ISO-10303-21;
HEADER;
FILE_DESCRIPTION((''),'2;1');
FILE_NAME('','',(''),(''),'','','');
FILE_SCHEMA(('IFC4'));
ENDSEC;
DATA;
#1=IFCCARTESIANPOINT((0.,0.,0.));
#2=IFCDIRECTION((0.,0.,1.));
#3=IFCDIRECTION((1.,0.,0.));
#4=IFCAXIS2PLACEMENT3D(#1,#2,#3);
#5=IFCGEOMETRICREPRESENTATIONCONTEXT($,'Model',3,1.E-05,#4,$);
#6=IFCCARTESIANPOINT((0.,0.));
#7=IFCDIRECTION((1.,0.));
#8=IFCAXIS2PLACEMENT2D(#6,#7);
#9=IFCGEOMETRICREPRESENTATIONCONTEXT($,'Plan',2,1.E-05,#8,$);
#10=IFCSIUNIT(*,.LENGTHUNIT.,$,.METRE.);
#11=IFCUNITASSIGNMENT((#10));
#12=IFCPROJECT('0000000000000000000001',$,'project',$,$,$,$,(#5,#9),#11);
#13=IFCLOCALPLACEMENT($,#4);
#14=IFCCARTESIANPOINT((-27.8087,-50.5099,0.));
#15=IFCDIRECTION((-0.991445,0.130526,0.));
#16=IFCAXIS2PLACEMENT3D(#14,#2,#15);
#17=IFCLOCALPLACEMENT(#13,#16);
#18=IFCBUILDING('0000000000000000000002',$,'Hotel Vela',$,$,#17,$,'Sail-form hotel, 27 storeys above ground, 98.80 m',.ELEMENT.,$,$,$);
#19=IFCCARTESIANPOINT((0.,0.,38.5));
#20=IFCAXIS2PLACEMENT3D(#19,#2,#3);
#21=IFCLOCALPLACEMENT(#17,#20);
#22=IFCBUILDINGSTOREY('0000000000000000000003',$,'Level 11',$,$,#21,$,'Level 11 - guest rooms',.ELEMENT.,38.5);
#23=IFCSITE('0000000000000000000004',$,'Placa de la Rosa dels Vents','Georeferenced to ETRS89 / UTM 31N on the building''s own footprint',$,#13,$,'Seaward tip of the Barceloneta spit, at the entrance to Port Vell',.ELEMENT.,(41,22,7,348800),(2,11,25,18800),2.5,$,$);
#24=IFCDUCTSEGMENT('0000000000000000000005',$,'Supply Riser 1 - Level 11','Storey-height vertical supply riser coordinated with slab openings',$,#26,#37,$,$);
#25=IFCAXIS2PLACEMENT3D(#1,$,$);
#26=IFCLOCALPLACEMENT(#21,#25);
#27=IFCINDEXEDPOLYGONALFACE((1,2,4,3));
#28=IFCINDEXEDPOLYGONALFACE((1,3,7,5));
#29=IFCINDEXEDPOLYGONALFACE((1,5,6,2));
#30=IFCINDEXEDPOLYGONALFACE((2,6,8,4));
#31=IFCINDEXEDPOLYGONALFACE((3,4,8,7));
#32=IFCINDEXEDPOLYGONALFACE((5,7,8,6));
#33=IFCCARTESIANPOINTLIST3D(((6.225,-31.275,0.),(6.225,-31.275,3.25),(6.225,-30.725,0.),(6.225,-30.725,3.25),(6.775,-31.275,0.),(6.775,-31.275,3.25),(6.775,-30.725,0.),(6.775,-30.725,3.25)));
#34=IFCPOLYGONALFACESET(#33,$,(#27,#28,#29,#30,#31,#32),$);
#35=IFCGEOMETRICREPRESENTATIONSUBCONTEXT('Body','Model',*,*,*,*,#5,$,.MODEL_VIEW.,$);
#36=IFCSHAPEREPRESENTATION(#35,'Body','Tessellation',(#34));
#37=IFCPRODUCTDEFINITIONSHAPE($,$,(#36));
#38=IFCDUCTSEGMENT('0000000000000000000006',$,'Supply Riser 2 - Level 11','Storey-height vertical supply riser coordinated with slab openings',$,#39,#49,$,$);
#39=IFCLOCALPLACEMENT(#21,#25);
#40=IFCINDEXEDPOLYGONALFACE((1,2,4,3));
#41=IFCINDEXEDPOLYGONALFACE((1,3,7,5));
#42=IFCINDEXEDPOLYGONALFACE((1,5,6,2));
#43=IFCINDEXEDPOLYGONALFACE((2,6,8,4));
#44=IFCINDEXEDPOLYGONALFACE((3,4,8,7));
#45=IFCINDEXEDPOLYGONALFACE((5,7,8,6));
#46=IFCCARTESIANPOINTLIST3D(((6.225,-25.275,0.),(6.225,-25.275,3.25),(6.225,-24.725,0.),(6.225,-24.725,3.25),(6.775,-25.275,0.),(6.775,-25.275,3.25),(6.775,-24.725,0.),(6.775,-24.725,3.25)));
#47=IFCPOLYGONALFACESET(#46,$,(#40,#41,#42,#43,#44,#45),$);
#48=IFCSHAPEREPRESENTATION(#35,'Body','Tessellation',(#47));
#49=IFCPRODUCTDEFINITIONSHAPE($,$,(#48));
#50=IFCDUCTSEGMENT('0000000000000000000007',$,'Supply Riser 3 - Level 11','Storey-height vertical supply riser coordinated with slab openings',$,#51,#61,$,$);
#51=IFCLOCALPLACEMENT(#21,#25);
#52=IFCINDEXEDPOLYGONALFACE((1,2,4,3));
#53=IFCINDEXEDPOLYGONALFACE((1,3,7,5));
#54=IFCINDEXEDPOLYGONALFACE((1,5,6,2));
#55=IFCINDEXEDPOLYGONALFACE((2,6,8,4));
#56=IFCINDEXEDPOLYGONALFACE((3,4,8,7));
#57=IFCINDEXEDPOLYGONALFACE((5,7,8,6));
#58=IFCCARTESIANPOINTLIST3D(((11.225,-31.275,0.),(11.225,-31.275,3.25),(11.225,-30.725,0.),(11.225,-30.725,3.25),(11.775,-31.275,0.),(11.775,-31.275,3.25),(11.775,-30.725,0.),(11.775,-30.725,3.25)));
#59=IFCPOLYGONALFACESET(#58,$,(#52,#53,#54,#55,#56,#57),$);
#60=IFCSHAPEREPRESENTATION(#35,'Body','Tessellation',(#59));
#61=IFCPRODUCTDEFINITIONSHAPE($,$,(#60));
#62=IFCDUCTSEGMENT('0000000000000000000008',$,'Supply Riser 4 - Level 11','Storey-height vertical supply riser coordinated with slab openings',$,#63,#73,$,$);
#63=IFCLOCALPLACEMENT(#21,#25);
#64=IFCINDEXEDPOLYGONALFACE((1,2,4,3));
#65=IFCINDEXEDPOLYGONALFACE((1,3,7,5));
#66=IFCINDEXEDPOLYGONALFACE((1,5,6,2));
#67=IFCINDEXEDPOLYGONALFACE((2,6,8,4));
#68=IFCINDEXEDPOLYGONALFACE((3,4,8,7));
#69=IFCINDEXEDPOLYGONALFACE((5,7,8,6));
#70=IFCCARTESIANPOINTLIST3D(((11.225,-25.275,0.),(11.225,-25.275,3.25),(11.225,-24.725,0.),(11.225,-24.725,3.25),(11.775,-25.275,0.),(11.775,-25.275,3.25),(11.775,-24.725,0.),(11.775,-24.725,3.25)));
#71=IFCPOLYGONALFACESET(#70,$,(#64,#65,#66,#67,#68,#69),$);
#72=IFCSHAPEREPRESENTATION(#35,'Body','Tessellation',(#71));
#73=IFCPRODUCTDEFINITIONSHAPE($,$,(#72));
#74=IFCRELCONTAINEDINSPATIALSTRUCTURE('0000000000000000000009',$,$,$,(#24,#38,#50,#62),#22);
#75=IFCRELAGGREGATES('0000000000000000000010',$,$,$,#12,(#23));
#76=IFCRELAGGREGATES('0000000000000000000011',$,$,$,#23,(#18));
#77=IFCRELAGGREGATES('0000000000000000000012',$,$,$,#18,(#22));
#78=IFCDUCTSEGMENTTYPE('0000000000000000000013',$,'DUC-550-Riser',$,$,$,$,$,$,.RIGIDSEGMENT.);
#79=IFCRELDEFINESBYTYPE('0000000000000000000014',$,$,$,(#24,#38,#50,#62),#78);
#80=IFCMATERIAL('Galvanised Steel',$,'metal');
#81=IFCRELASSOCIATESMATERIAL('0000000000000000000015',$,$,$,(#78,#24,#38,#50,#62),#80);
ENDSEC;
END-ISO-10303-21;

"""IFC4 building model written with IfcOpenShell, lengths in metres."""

from ifc_helpers import new_model, si_unit, frame, origin_with_axes, origin_2d_with_axis, place, context, subcontext, project, spatial, line, indexed_curve, outline, extrude, material, type_object, element, save


model = new_model("IFC4")

# Units and contexts
model_context = context("Model", 3, precision=1e-05, world=origin_with_axes())
plan_context = context("Plan", 2, precision=1e-05, world=origin_2d_with_axis())
body_context = subcontext(model_context, "Body", "Model", "MODEL_VIEW")
ifc_project = project(units=[si_unit("LENGTHUNIT", "METRE")], contexts=[model_context, plan_context])

# Site, building, storey
site_placement = place(None, origin_with_axes())
site = spatial("IfcSite", under=ifc_project, at=site_placement, Name="Placa de la Rosa dels Vents", Description="Georeferenced to ETRS89 / UTM 31N on the building's own footprint", LongName="Seaward tip of the Barceloneta spit, at the entrance to Port Vell", CompositionType="ELEMENT", RefLatitude=(41, 22, 7, 348800), RefLongitude=(2, 11, 25, 18800), RefElevation=2.5)
building_placement = place(site_placement, frame((-27.8087, -50.5099, 0.0), z_axis=(0.0, 0.0, 1.0), x_axis=(-0.991445, 0.130526, 0.0)))
building = spatial("IfcBuilding", under=site, at=building_placement, Name="Hotel Vela", LongName="Sail-form hotel, 27 storeys above ground, 98.80 m", CompositionType="ELEMENT")
storey_placement = place(building_placement, frame((0.0, 0.0, 38.5), z_axis=(0.0, 0.0, 1.0), x_axis=(1.0, 0.0, 0.0)))
storey = spatial("IfcBuildingStorey", under=building, at=storey_placement, Name="Level 11", LongName="Level 11 - guest rooms", CompositionType="ELEMENT", Elevation=38.5)

# Duct segments
ifc_material = material(Name="Galvanised Steel", Category="metal")
duct_segment_type = type_object("IfcDuctSegmentType", Name="DUC-550-Riser", PredefinedType="RIGIDSEGMENT", material=ifc_material)
for number, where, z_axis, x_axis, name in (
    (1, (6.225, -31.275, 0.0), (0.0, 0.0, 1.0), (1.0, 0.0, 0.0), "Supply Riser 1 - Level 11"),
    (2, (6.225, -25.275, 0.0), (0.0, 0.0, 1.0), (1.0, 0.0, 0.0), "Supply Riser 2 - Level 11"),
    (3, (11.225, -31.275, 0.0), (0.0, 0.0, 1.0), (1.0, 0.0, 0.0), "Supply Riser 3 - Level 11"),
    (4, (11.225, -25.275, 0.0), (0.0, 0.0, 1.0), (1.0, 0.0, 0.0), "Supply Riser 4 - Level 11"),
):
    element("IfcDuctSegment", number, at=place(storey_placement, frame(where, z_axis=z_axis, x_axis=x_axis)), inside=storey, type_object=duct_segment_type, material=ifc_material, Name=name, Description="Storey-height vertical supply riser coordinated with slab openings", context=body_context, shape_type="SweptSolid", body=[
        extrude(outline(indexed_curve([(0.0, 0.0), (0.55, 0.0), (0.55, 0.55), (0.0, 0.55)], segments=[line(1, 2, 3, 4, 1)])), origin_with_axes(), (0.0, 0.0, 1.0), 3.25),
    ])

save(model, "model.ifc")
